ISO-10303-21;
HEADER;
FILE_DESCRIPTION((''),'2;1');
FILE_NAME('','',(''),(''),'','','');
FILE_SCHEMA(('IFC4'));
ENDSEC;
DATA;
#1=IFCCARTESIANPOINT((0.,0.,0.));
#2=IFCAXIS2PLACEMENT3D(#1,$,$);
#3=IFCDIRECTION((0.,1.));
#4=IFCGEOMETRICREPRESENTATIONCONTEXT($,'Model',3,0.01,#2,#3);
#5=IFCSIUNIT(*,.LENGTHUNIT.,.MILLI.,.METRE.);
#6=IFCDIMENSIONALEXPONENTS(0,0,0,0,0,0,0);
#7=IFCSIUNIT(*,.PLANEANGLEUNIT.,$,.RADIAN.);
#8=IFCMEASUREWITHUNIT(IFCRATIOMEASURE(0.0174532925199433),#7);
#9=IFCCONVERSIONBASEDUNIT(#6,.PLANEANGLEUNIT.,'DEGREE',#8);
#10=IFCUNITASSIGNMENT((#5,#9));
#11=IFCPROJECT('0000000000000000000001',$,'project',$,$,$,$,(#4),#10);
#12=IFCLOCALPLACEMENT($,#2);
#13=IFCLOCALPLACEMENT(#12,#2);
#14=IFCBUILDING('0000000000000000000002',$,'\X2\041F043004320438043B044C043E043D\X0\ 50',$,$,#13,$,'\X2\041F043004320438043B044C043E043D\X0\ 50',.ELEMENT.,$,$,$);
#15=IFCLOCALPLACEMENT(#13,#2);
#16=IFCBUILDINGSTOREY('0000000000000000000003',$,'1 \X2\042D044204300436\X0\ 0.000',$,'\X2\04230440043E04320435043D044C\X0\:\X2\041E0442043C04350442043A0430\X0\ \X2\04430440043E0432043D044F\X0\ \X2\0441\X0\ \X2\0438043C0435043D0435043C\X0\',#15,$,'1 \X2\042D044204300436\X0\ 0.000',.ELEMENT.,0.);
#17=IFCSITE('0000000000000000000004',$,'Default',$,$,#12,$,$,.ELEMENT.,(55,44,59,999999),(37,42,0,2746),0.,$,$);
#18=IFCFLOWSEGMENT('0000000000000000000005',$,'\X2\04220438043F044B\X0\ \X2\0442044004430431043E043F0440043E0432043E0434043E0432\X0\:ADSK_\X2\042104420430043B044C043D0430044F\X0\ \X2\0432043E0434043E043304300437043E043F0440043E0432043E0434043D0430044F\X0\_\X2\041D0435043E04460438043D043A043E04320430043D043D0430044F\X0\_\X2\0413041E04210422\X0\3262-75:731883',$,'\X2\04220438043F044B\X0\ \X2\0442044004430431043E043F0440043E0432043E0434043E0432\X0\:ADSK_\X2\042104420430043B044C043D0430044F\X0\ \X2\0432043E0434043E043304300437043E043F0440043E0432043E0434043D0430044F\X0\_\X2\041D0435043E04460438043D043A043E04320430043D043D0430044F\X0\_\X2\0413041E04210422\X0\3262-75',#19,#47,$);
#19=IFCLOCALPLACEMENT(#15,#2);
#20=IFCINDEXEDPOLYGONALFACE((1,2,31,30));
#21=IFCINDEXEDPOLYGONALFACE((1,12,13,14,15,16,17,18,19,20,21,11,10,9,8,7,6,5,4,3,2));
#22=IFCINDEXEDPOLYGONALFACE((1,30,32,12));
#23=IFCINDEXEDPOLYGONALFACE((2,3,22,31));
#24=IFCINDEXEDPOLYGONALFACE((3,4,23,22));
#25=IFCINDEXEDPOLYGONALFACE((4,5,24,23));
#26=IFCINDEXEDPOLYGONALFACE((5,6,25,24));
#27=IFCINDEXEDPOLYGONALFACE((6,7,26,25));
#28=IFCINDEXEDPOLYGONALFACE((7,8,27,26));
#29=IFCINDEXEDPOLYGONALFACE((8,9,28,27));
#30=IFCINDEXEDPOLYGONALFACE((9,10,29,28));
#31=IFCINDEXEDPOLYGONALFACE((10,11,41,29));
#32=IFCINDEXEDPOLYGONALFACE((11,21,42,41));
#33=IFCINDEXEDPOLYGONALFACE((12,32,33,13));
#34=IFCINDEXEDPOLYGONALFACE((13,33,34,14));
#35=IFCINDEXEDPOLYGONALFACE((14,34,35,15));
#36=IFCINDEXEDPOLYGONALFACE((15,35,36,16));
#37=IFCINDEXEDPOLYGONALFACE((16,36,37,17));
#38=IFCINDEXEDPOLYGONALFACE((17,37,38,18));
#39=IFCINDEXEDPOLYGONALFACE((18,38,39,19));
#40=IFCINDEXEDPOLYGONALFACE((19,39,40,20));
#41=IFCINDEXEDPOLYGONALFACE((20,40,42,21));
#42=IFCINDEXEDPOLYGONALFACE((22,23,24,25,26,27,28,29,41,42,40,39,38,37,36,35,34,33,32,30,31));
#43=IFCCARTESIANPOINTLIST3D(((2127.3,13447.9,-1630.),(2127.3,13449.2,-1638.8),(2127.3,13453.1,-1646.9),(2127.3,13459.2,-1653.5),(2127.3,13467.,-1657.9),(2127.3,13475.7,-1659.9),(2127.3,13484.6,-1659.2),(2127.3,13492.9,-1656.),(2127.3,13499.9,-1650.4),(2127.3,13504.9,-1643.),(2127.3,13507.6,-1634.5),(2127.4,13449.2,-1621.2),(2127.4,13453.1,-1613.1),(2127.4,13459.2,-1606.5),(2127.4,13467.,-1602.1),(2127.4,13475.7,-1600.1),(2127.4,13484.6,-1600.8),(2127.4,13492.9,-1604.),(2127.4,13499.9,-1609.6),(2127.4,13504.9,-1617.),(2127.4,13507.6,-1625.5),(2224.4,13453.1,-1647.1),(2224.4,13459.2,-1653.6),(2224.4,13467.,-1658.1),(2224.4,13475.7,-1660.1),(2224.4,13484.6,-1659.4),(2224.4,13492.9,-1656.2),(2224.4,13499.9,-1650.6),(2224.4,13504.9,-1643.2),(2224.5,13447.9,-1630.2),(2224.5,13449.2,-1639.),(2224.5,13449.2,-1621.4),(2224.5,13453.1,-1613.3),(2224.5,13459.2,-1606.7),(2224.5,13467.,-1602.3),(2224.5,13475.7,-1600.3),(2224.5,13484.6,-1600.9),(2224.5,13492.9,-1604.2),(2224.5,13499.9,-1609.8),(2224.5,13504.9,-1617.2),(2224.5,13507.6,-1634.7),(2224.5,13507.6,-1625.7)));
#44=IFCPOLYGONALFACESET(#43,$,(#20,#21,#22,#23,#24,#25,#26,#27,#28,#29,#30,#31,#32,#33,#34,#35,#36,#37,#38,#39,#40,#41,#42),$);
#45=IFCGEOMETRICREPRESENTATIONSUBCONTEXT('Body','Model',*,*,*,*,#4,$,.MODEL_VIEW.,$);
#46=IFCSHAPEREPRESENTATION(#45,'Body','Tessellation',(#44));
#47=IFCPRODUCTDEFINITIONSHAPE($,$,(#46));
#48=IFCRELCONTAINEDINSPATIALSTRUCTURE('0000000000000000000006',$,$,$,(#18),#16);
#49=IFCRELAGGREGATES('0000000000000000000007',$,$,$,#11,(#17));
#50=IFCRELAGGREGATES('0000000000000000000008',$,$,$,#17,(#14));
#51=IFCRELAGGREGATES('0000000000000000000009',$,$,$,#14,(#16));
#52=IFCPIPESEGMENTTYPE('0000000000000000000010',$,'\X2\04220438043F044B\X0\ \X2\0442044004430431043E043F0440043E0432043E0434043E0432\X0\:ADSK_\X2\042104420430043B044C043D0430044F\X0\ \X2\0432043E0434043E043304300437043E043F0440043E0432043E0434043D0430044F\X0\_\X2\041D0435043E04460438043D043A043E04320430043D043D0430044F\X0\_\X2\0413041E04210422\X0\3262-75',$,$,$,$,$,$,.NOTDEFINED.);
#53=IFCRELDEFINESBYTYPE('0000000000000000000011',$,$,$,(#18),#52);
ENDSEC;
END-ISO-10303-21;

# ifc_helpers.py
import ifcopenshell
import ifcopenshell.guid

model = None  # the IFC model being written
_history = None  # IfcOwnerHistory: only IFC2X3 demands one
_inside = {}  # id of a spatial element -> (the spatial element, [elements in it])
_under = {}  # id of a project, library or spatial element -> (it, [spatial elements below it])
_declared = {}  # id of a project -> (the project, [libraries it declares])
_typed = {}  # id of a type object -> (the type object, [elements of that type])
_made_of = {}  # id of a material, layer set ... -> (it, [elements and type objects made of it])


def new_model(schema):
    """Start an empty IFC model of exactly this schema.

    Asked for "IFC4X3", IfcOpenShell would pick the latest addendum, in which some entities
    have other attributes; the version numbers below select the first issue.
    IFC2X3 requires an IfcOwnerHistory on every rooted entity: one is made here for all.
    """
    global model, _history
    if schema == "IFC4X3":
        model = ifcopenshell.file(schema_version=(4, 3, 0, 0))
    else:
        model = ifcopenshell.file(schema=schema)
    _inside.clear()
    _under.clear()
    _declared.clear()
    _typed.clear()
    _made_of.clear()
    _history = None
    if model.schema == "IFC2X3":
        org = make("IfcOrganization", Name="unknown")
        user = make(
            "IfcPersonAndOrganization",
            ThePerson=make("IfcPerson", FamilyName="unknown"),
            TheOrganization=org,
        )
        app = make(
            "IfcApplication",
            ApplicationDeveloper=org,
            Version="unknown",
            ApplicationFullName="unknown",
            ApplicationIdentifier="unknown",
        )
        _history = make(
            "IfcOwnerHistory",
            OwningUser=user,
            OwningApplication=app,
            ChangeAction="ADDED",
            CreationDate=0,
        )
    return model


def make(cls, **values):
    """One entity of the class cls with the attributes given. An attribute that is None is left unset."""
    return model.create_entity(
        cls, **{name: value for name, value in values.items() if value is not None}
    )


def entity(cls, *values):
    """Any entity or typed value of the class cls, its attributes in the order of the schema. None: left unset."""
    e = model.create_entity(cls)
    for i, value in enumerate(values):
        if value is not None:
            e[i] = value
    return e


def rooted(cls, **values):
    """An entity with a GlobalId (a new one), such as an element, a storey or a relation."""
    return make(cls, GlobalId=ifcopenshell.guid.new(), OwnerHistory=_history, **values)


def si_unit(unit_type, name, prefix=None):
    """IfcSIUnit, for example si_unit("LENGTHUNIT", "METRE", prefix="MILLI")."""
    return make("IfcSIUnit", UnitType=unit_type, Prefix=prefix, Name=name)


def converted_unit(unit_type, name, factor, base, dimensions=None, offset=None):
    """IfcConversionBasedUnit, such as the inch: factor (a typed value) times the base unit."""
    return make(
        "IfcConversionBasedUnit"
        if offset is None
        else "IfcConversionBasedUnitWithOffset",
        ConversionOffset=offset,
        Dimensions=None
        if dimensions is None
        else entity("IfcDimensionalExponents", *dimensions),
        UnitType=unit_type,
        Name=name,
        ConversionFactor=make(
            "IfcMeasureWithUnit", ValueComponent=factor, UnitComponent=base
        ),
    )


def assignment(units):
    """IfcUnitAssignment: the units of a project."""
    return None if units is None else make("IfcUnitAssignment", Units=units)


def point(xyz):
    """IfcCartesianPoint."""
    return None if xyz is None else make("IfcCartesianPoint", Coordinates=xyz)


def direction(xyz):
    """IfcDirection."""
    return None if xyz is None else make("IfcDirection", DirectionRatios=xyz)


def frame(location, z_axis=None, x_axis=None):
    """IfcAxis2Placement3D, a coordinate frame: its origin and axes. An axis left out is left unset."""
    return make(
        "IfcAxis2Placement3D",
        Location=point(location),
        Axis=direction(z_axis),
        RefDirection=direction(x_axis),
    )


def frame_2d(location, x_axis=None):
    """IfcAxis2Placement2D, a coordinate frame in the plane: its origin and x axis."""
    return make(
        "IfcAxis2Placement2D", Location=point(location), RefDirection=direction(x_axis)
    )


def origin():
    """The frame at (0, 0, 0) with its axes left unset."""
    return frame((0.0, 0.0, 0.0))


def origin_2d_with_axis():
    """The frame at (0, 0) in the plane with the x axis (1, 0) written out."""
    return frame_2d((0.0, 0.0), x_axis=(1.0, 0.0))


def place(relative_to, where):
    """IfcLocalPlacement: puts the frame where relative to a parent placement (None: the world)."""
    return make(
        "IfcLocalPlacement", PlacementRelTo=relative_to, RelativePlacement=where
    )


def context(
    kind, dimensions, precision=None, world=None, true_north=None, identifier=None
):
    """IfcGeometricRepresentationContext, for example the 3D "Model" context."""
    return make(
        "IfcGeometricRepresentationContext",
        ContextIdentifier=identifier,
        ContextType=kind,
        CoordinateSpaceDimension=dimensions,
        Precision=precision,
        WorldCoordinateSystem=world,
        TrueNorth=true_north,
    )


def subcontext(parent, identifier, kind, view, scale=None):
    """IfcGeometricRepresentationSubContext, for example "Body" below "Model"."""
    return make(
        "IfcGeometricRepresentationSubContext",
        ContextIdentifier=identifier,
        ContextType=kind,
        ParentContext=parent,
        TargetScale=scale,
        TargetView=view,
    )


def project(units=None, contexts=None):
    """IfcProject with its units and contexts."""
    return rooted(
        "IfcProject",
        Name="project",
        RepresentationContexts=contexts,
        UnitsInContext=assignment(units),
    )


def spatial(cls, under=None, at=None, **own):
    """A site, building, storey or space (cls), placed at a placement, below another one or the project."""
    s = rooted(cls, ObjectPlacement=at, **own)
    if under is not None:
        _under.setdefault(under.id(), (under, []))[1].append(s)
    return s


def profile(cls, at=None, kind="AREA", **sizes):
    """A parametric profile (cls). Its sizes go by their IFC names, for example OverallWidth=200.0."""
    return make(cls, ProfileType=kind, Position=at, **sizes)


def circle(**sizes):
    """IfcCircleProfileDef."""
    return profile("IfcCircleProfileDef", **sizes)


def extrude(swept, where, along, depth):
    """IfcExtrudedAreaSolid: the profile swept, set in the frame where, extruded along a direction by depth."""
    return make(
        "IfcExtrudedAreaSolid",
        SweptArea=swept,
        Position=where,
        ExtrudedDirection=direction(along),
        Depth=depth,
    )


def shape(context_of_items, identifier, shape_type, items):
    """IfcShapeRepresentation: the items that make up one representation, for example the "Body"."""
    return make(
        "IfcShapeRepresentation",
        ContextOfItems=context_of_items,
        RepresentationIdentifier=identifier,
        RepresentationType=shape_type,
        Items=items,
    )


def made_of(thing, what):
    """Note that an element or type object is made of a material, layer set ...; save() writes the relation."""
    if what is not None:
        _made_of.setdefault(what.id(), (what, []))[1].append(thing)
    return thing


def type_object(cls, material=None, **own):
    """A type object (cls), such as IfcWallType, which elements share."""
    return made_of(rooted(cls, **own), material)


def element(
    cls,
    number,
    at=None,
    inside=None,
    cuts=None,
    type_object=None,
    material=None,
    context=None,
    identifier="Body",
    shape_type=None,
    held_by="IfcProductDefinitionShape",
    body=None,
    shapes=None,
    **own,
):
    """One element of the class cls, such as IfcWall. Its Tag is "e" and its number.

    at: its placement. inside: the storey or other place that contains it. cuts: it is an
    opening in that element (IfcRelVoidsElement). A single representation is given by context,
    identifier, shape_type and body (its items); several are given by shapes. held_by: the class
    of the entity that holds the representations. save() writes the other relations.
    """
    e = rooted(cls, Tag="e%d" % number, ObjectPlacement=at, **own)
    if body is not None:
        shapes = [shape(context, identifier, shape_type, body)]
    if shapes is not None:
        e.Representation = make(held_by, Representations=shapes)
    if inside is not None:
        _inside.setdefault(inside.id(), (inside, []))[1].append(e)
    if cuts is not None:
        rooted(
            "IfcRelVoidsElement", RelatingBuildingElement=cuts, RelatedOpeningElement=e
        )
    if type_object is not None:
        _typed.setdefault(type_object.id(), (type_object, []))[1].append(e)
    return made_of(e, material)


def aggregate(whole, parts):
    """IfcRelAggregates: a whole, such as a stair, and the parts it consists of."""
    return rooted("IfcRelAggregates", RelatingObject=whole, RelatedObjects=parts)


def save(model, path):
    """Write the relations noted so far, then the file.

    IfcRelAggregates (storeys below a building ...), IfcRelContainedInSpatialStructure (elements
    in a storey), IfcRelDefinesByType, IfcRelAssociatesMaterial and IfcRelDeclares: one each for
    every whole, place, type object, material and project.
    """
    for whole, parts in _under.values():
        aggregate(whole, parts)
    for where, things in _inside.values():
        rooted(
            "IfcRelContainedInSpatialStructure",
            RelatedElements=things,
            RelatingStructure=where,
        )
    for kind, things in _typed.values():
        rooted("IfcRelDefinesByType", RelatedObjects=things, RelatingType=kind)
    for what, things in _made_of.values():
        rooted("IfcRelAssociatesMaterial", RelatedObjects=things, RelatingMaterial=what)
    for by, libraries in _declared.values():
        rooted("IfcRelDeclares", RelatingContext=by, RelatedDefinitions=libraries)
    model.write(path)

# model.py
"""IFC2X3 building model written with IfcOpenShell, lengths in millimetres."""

from ifc_helpers import new_model, entity, si_unit, converted_unit, direction, frame, origin, origin_2d_with_axis, place, context, subcontext, project, spatial, circle, extrude, type_object, element, save


model = new_model("IFC2X3")

# Units and contexts
model_context = context("Model", 3, precision=0.01, world=origin(), true_north=direction((0.0, 1.0)))
body_context = subcontext(model_context, "Body", "Model", "MODEL_VIEW")
ifc_project = project(units=[si_unit("LENGTHUNIT", "METRE", prefix="MILLI"), converted_unit("PLANEANGLEUNIT", "DEGREE", entity("IfcRatioMeasure", 0.0174532925199433), si_unit("PLANEANGLEUNIT", "RADIAN"), dimensions=[0, 0, 0, 0, 0, 0, 0])], contexts=[model_context])

# Site, building, storey
site_placement = place(None, origin())
site = spatial("IfcSite", under=ifc_project, at=site_placement, Name="Default", CompositionType="ELEMENT", RefLatitude=(55, 44, 59, 999999), RefLongitude=(37, 42, 0, 2746), RefElevation=0.0)
building_placement = place(site_placement, origin())
building = spatial("IfcBuilding", under=site, at=building_placement, Name="Павильон 50", LongName="Павильон 50", CompositionType="ELEMENT")
storey_placement = place(building_placement, origin())
storey = spatial("IfcBuildingStorey", under=building, at=storey_placement, Name="1 Этаж 0.000", ObjectType="Уровень:Отметка уровня с именем", LongName="1 Этаж 0.000", CompositionType="ELEMENT", Elevation=0.0)

# Flow segment
pipe_segment_type = type_object("IfcPipeSegmentType", Name="Типы трубопроводов:ADSK_Стальная водогазопроводная_Неоцинкованная_ГОСТ3262-75", PredefinedType="NOTDEFINED")
flow_segment_1_placement = place(storey_placement, frame((2127.3, 13446.3, -1661.8)))
element("IfcFlowSegment", 1, at=flow_segment_1_placement, inside=storey, type_object=pipe_segment_type, Name="Типы трубопроводов:ADSK_Стальная водогазопроводная_Неоцинкованная_ГОСТ3262-75:731883", ObjectType="Типы трубопроводов:ADSK_Стальная водогазопроводная_Неоцинкованная_ГОСТ3262-75", context=body_context, shape_type="SweptSolid", body=[
    extrude(circle(Radius=30.0, at=origin_2d_with_axis()), frame((97.2, 31.6, 31.6), z_axis=(-0.999998, 0.0, 0.002), x_axis=(0.0, -1.0, 0.0)), (0.0, 0.0, 1.0), 97.1),
])

save(model, "model.ifc")
